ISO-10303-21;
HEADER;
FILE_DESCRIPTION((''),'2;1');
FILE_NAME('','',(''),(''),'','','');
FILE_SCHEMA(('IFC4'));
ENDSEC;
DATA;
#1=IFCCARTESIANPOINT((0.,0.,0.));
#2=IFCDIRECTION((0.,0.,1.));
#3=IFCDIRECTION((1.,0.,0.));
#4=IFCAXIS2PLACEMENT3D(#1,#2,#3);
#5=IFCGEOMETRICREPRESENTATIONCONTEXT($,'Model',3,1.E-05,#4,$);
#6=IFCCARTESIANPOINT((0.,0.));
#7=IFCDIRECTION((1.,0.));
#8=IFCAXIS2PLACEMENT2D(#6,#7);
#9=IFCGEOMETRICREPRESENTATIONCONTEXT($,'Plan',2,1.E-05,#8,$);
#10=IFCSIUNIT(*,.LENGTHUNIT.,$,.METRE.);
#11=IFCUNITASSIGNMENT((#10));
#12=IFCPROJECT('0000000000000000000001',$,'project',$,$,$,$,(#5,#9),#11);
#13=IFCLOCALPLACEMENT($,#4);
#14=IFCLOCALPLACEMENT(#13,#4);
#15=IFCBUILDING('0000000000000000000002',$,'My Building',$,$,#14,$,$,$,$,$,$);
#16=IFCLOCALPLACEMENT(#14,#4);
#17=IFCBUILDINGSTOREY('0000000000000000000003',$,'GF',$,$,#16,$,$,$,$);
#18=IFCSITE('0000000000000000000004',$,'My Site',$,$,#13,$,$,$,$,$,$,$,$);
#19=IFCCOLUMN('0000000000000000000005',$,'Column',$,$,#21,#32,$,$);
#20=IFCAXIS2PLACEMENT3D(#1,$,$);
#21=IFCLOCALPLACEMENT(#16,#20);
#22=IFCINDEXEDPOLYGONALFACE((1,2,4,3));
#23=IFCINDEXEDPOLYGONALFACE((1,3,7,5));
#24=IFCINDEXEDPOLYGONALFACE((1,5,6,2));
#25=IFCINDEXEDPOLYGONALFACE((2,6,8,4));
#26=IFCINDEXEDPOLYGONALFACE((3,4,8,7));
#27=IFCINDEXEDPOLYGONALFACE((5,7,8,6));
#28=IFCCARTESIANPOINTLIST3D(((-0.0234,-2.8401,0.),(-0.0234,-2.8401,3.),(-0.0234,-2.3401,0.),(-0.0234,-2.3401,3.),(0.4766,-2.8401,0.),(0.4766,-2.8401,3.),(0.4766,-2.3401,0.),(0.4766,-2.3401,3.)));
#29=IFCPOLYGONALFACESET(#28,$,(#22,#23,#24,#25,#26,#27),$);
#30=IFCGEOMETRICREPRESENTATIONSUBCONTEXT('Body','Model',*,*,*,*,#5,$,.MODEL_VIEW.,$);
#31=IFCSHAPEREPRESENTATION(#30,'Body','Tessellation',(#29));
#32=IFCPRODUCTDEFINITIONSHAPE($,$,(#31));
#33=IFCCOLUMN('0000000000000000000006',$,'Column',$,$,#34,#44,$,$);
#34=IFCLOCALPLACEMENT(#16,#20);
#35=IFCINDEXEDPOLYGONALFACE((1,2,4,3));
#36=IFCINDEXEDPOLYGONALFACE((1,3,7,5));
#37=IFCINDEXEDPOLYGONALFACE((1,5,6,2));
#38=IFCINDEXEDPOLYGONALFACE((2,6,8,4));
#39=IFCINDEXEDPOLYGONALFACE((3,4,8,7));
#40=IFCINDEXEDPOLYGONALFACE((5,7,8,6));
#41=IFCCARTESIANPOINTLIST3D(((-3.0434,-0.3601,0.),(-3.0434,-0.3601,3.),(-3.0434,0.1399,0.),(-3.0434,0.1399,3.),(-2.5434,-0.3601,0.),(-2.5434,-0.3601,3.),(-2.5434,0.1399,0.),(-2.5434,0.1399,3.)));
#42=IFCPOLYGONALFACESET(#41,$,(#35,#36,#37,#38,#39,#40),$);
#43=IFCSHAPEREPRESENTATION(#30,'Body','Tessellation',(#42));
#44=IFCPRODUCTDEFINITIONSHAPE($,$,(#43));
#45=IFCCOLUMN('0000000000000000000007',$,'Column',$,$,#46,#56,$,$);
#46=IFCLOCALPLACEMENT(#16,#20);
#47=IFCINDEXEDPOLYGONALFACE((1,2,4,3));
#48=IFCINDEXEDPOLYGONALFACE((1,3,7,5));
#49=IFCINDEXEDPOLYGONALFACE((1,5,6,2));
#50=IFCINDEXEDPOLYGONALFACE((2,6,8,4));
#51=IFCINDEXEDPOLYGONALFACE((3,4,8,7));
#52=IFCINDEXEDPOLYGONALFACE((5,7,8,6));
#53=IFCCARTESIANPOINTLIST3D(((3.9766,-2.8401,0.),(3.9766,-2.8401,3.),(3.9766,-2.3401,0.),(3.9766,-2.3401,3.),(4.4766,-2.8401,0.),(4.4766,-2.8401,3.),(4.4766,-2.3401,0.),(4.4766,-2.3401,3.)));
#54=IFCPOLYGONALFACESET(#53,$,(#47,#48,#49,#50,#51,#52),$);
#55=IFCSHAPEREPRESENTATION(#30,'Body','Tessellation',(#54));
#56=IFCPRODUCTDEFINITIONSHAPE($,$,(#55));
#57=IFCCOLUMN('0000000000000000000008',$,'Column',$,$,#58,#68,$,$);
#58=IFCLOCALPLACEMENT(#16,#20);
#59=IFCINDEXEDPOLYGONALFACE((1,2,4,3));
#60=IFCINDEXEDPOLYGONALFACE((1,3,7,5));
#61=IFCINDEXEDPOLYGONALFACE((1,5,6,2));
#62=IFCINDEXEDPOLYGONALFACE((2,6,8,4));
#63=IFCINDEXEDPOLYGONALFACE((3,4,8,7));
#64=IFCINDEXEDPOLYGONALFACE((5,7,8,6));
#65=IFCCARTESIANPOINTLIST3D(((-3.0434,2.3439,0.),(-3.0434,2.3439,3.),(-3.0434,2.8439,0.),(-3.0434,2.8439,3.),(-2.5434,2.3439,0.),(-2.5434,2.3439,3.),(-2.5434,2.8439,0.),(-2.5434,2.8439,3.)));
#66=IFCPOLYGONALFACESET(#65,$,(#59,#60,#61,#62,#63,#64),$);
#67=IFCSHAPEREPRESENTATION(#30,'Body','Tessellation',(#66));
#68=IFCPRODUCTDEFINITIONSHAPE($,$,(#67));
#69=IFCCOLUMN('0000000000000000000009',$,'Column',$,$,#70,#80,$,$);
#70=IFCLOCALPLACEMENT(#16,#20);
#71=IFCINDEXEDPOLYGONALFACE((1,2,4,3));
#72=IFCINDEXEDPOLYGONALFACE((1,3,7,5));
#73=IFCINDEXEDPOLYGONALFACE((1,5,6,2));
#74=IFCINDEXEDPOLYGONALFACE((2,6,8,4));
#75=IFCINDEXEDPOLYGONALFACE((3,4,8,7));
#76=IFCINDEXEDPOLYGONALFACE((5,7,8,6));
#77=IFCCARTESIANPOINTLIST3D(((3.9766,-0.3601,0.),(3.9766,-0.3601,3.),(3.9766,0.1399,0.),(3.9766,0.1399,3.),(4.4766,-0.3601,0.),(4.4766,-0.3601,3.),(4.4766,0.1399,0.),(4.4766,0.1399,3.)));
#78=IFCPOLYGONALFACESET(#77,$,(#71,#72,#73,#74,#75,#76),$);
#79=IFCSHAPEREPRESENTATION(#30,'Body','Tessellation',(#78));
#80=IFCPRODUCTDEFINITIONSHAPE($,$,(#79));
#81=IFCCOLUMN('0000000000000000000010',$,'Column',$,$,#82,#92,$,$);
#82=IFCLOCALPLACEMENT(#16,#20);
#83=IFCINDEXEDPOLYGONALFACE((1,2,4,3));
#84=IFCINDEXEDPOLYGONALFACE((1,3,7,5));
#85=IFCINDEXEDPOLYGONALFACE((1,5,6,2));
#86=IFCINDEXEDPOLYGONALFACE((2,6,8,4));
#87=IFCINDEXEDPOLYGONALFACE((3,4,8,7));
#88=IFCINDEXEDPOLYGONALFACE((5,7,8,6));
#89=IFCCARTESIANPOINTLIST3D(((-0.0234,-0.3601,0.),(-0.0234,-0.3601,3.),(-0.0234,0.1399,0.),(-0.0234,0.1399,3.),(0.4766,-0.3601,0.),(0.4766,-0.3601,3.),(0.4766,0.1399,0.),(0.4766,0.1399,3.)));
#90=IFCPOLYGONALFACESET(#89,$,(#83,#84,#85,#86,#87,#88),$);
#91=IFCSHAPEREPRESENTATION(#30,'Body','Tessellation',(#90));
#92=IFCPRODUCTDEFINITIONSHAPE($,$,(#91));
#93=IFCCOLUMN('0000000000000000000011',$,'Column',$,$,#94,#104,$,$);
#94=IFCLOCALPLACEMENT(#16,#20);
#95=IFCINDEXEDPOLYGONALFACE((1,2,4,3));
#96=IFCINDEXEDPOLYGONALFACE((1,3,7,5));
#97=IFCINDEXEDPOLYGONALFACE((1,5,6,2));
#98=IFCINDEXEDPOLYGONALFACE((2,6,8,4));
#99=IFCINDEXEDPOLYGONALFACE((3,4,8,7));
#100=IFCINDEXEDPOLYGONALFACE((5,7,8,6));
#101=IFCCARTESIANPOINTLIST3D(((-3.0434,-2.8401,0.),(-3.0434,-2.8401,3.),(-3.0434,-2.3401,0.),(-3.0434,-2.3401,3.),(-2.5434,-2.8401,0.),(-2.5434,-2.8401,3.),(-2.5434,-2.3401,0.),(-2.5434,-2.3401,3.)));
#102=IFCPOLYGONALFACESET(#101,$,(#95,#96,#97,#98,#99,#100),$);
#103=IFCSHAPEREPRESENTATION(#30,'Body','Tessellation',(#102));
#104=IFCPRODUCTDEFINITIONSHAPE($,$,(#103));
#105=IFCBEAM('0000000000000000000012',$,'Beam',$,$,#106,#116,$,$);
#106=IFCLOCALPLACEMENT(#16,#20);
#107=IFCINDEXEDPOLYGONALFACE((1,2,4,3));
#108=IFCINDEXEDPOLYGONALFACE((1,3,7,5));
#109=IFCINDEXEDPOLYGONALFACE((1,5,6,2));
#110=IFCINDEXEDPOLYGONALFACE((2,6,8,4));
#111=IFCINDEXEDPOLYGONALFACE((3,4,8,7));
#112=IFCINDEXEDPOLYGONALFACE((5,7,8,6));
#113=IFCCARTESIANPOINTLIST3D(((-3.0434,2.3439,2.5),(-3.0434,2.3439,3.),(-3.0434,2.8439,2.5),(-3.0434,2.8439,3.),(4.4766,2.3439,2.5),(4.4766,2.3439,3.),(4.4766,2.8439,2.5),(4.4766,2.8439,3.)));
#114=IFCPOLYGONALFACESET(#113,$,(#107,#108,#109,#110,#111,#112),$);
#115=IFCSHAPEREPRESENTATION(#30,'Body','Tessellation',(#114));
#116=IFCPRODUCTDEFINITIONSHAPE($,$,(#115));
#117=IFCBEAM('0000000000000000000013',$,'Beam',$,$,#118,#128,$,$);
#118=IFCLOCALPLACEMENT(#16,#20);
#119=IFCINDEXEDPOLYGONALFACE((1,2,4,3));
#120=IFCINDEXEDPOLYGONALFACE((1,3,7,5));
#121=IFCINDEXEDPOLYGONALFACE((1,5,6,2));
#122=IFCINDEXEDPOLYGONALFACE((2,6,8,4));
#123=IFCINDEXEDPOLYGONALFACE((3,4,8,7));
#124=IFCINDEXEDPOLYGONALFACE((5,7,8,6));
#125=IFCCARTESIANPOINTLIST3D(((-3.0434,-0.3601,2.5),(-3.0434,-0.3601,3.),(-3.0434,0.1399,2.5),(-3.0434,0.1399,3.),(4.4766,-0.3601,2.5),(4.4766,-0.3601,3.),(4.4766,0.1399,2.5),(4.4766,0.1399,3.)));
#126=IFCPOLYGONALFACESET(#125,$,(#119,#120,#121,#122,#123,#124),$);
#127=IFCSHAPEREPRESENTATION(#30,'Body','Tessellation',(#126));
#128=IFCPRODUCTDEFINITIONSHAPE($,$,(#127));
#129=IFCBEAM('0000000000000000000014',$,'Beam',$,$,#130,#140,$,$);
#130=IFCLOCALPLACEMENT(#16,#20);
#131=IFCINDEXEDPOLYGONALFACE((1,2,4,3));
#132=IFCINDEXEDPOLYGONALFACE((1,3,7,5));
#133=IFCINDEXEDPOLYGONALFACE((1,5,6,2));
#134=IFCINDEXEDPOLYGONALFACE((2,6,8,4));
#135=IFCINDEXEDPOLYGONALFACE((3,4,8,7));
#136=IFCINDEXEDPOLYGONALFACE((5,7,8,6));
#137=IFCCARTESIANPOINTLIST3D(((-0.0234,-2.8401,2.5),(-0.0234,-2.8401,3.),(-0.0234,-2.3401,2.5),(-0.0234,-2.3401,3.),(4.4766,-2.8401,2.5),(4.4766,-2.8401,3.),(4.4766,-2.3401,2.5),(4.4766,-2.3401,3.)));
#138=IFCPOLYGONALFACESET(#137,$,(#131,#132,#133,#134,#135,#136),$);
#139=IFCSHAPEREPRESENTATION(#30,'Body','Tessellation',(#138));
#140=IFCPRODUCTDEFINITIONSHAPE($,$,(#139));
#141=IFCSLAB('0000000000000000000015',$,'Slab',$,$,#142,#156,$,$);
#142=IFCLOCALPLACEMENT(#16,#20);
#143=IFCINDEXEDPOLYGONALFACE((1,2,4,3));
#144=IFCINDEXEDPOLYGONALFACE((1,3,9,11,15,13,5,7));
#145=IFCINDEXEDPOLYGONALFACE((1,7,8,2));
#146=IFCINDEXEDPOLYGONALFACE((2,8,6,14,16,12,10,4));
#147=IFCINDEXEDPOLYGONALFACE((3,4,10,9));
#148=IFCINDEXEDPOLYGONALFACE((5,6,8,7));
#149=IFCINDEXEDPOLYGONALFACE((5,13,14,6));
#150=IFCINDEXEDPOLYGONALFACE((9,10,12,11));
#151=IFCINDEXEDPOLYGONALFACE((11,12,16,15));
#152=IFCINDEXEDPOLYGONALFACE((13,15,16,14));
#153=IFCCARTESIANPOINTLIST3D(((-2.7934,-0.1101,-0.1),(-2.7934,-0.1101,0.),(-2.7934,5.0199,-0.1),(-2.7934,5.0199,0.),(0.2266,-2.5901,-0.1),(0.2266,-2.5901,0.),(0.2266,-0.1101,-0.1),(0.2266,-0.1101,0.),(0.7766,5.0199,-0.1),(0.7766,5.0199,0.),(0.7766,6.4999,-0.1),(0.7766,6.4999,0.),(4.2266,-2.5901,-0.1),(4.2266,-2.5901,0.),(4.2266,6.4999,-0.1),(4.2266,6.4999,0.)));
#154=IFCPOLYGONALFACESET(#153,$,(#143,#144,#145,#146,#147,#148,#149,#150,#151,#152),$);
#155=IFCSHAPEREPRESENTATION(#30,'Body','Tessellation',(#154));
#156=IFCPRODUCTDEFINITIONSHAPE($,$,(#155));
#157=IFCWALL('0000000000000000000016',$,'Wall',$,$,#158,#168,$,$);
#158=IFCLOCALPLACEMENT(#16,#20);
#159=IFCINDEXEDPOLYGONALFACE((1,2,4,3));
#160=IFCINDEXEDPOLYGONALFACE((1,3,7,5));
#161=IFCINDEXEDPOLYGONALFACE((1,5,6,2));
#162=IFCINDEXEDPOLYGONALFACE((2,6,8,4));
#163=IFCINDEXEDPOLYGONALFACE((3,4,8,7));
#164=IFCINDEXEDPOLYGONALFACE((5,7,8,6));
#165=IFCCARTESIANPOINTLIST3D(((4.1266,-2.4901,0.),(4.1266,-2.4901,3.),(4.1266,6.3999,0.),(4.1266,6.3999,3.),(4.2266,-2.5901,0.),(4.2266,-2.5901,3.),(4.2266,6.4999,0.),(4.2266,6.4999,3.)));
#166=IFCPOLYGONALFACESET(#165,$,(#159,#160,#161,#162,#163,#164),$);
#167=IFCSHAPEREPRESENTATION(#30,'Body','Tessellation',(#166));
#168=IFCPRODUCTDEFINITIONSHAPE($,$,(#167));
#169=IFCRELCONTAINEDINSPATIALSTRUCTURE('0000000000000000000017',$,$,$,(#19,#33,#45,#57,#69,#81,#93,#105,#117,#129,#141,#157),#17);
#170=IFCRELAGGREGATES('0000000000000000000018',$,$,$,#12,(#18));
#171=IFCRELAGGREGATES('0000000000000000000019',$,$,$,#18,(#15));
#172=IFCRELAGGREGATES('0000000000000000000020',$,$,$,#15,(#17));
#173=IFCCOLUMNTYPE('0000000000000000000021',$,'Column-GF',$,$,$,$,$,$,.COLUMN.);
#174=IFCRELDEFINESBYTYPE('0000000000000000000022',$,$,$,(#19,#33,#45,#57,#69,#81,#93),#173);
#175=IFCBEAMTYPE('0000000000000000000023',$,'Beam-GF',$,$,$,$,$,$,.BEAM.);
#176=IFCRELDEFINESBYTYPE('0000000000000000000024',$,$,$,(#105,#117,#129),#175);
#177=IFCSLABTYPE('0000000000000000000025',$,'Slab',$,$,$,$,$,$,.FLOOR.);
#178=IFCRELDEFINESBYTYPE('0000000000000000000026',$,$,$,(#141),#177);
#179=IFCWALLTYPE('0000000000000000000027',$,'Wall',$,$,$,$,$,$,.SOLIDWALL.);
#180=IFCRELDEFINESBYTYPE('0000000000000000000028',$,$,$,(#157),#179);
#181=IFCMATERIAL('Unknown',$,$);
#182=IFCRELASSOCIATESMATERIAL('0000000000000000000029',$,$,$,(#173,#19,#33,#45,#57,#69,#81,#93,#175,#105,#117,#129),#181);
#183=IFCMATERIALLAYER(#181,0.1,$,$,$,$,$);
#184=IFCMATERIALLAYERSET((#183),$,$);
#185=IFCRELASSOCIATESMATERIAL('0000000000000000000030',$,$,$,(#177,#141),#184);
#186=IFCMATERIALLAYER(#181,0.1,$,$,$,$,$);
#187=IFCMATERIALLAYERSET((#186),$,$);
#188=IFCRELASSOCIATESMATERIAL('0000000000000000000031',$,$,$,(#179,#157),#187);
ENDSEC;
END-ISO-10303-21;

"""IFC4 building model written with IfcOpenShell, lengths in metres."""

from ifc_helpers import new_model, si_unit, frame, origin_with_axes, origin_2d_with_axis, place, context, subcontext, project, spatial, line, indexed_curve, rectangle, outline, extrude, material, layer, layer_set, layer_usage, material_profile, profile_set, profile_usage, type_object, element, save


model = new_model("IFC4")

# Units and contexts
model_context = context("Model", 3, precision=1e-05, world=origin_with_axes())
plan_context = context("Plan", 2, precision=1e-05, world=origin_2d_with_axis())
body_context_1 = subcontext(model_context, "Body", "Model", "MODEL_VIEW")
ifc_project = project(units=[si_unit("LENGTHUNIT", "METRE")], contexts=[model_context, plan_context])

# Site, building, storey
site_placement = place(None, origin_with_axes())
site = spatial("IfcSite", under=ifc_project, at=site_placement, Name="My Site")
building_placement = place(site_placement, origin_with_axes())
building = spatial("IfcBuilding", under=site, at=building_placement, Name="My Building")
storey_placement = place(building_placement, origin_with_axes())
storey = spatial("IfcBuildingStorey", under=building, at=storey_placement, Name="GF")

# Columns
ifc_material = material(Name="Unknown")
ifc_material_profile_1 = material_profile(ifc_material, rectangle(XDim=0.5, YDim=0.5))
ifc_profile_set_1 = profile_set([ifc_material_profile_1])
ifc_profile_usage_1 = profile_usage(ifc_profile_set_1, cardinal=5)
column_type = type_object("IfcColumnType", Name="Column-GF", PredefinedType="COLUMN", material=ifc_profile_set_1)
column_1_placement = place(storey_placement, frame((0.2266, -2.5901, 0.0), z_axis=(0.0, 0.0, 1.0), x_axis=(1.0, 0.0, 0.0)))
element("IfcColumn", 1, at=column_1_placement, inside=storey, type_object=column_type, material=ifc_profile_usage_1, Name="Column", context=body_context_1, shape_type="SweptSolid", body=[
    extrude(rectangle(XDim=0.5, YDim=0.5), origin_with_axes(), (0.0, 0.0, 1.0), 3.0),
])
ifc_profile_usage_2 = profile_usage(ifc_profile_set_1, cardinal=5)
column_2_placement = place(storey_placement, frame((-2.7934, -0.1101, 0.0), z_axis=(0.0, 0.0, 1.0), x_axis=(1.0, 0.0, 0.0)))
element("IfcColumn", 2, at=column_2_placement, inside=storey, type_object=column_type, material=ifc_profile_usage_2, Name="Column", context=body_context_1, shape_type="SweptSolid", body=[
    extrude(rectangle(XDim=0.5, YDim=0.5), origin_with_axes(), (0.0, 0.0, 1.0), 3.0),
])
ifc_profile_usage_3 = profile_usage(ifc_profile_set_1, cardinal=5)
column_3_placement = place(storey_placement, frame((4.2266, -2.5901, 0.0), z_axis=(0.0, 0.0, 1.0), x_axis=(1.0, 0.0, 0.0)))
element("IfcColumn", 3, at=column_3_placement, inside=storey, type_object=column_type, material=ifc_profile_usage_3, Name="Column", context=body_context_1, shape_type="SweptSolid", body=[
    extrude(rectangle(XDim=0.5, YDim=0.5), origin_with_axes(), (0.0, 0.0, 1.0), 3.0),
])
ifc_profile_usage_4 = profile_usage(ifc_profile_set_1, cardinal=5)
column_4_placement = place(storey_placement, frame((-2.7934, 2.5939, 0.0), z_axis=(0.0, 0.0, 1.0), x_axis=(1.0, 0.0, 0.0)))
element("IfcColumn", 4, at=column_4_placement, inside=storey, type_object=column_type, material=ifc_profile_usage_4, Name="Column", context=body_context_1, shape_type="SweptSolid", body=[
    extrude(rectangle(XDim=0.5, YDim=0.5), origin_with_axes(), (0.0, 0.0, 1.0), 3.0),
])
ifc_profile_usage_5 = profile_usage(ifc_profile_set_1, cardinal=5)
column_5_placement = place(storey_placement, frame((4.2266, -0.1101, 0.0), z_axis=(0.0, 0.0, 1.0), x_axis=(1.0, 0.0, 0.0)))
element("IfcColumn", 5, at=column_5_placement, inside=storey, type_object=column_type, material=ifc_profile_usage_5, Name="Column", context=body_context_1, shape_type="SweptSolid", body=[
    extrude(rectangle(XDim=0.5, YDim=0.5), origin_with_axes(), (0.0, 0.0, 1.0), 3.0),
])
ifc_profile_usage_6 = profile_usage(ifc_profile_set_1, cardinal=5)
column_6_placement = place(storey_placement, frame((0.2266, -0.1101, 0.0), z_axis=(0.0, 0.0, 1.0), x_axis=(1.0, 0.0, 0.0)))
element("IfcColumn", 6, at=column_6_placement, inside=storey, type_object=column_type, material=ifc_profile_usage_6, Name="Column", context=body_context_1, shape_type="SweptSolid", body=[
    extrude(rectangle(XDim=0.5, YDim=0.5), origin_with_axes(), (0.0, 0.0, 1.0), 3.0),
])
ifc_profile_usage_7 = profile_usage(ifc_profile_set_1, cardinal=5)
column_7_placement = place(storey_placement, frame((-2.7934, -2.5901, 0.0), z_axis=(0.0, 0.0, 1.0), x_axis=(1.0, 0.0, 0.0)))
element("IfcColumn", 7, at=column_7_placement, inside=storey, type_object=column_type, material=ifc_profile_usage_7, Name="Column", context=body_context_1, shape_type="SweptSolid", body=[
    extrude(rectangle(XDim=0.5, YDim=0.5), origin_with_axes(), (0.0, 0.0, 1.0), 3.0),
])

# Beams
ifc_material_profile_2 = material_profile(ifc_material, rectangle(XDim=0.5, YDim=0.5))
ifc_profile_set_2 = profile_set([ifc_material_profile_2])
ifc_profile_usage_8 = profile_usage(ifc_profile_set_2, cardinal=7)
beam_type = type_object("IfcBeamType", Name="Beam-GF", PredefinedType="BEAM", material=ifc_profile_set_2)
beam_1_placement = place(storey_placement, frame((4.4766, 2.3439, 3.0), z_axis=(-1.0, 0.0, 0.0), x_axis=(0.0, -1.0, 0.0)))
element("IfcBeam", 8, at=beam_1_placement, inside=storey, type_object=beam_type, material=ifc_profile_usage_8, Name="Beam", context=body_context_1, shape_type="SweptSolid", body=[
    extrude(rectangle(XDim=0.5, YDim=0.5), frame((-0.25, -0.25, 0.0), z_axis=(0.0, 0.0, 1.0), x_axis=(1.0, 0.0, 0.0)), (0.0, 0.0, 1.0), 7.52),
])
ifc_profile_usage_9 = profile_usage(ifc_profile_set_2, cardinal=7)
beam_2_placement = place(storey_placement, frame((4.4766, -0.3601, 3.0), z_axis=(-1.0, 0.0, 0.0), x_axis=(0.0, -1.0, 0.0)))
element("IfcBeam", 9, at=beam_2_placement, inside=storey, type_object=beam_type, material=ifc_profile_usage_9, Name="Beam", context=body_context_1, shape_type="SweptSolid", body=[
    extrude(rectangle(XDim=0.5, YDim=0.5), frame((-0.25, -0.25, 0.0), z_axis=(0.0, 0.0, 1.0), x_axis=(1.0, 0.0, 0.0)), (0.0, 0.0, 1.0), 7.52),
])
ifc_profile_usage_10 = profile_usage(ifc_profile_set_2, cardinal=7)
beam_3_placement = place(storey_placement, frame((4.4766, -2.8401, 3.0), z_axis=(-1.0, -0.000001, 0.000001), x_axis=(0.000001, -1.0, 0.0)))
element("IfcBeam", 10, at=beam_3_placement, inside=storey, type_object=beam_type, material=ifc_profile_usage_10, Name="Beam", context=body_context_1, shape_type="SweptSolid", body=[
    extrude(rectangle(XDim=0.5, YDim=0.5), frame((-0.25, -0.25, 0.0), z_axis=(0.0, 0.0, 1.0), x_axis=(1.0, 0.0, 0.0)), (0.0, 0.0, 1.0), 4.5),
])

# Slab
ifc_layer_1 = layer(ifc_material, 0.1)
ifc_layer_set_1 = layer_set([ifc_layer_1])
ifc_layer_usage_1 = layer_usage(ifc_layer_set_1, "AXIS3", "POSITIVE", -0.1)
slab_type_1 = type_object("IfcSlabType", Name="Slab", PredefinedType="FLOOR", material=ifc_layer_set_1)
slab_1_placement = place(storey_placement, frame((4.2266, -2.5901, 0.0), z_axis=(0.0, 0.0, 1.0), x_axis=(1.0, 0.0, 0.0)))
element("IfcSlab", 11, at=slab_1_placement, inside=storey, type_object=slab_type_1, material=ifc_layer_usage_1, Name="Slab", context=body_context_1, shape_type="SweptSolid", body=[
    extrude(outline(indexed_curve([(0.0, 0.0), (0.0, 9.09), (-3.45, 9.09), (-3.45, 7.61), (-7.02, 7.61), (-7.02, 2.48), (-4.0, 2.48), (-4.0, 0.0), (0.0, 0.0)])), frame((0.0, 0.0, -0.1), z_axis=(0.0, 0.0, 1.0), x_axis=(1.0, 0.0, 0.0)), (0.0, 0.0, 1.0), 0.1),
])

# Shared definitions
ifc_layer_2 = layer(ifc_material, 0.1)
ifc_layer_set_2 = layer_set([ifc_layer_2])
wall_type = type_object("IfcWallType", Name="Wall", PredefinedType="SOLIDWALL", material=ifc_layer_set_2)

# Wall
ifc_layer_usage_2 = layer_usage(ifc_layer_set_2, "AXIS2", "POSITIVE", 0.0)
wall_1_placement = place(storey_placement, frame((4.2266, -2.5901, 0.0), z_axis=(0.0, 0.0, 1.0), x_axis=(0.0, 1.0, 0.0)))
element("IfcWall", 12, at=wall_1_placement, inside=storey, type_object=wall_type, material=ifc_layer_usage_2, Name="Wall", context=body_context_1, shape_type="SweptSolid", body=[
    extrude(outline(indexed_curve([(0.0, 0.0), (0.1, 0.1), (8.99, 0.1), (9.09, 0.0)], segments=[line(1, 2, 3, 4, 1)])), origin_with_axes(), (0.0, 0.0, 1.0), 3.0),
])

save(model, "model.ifc")
